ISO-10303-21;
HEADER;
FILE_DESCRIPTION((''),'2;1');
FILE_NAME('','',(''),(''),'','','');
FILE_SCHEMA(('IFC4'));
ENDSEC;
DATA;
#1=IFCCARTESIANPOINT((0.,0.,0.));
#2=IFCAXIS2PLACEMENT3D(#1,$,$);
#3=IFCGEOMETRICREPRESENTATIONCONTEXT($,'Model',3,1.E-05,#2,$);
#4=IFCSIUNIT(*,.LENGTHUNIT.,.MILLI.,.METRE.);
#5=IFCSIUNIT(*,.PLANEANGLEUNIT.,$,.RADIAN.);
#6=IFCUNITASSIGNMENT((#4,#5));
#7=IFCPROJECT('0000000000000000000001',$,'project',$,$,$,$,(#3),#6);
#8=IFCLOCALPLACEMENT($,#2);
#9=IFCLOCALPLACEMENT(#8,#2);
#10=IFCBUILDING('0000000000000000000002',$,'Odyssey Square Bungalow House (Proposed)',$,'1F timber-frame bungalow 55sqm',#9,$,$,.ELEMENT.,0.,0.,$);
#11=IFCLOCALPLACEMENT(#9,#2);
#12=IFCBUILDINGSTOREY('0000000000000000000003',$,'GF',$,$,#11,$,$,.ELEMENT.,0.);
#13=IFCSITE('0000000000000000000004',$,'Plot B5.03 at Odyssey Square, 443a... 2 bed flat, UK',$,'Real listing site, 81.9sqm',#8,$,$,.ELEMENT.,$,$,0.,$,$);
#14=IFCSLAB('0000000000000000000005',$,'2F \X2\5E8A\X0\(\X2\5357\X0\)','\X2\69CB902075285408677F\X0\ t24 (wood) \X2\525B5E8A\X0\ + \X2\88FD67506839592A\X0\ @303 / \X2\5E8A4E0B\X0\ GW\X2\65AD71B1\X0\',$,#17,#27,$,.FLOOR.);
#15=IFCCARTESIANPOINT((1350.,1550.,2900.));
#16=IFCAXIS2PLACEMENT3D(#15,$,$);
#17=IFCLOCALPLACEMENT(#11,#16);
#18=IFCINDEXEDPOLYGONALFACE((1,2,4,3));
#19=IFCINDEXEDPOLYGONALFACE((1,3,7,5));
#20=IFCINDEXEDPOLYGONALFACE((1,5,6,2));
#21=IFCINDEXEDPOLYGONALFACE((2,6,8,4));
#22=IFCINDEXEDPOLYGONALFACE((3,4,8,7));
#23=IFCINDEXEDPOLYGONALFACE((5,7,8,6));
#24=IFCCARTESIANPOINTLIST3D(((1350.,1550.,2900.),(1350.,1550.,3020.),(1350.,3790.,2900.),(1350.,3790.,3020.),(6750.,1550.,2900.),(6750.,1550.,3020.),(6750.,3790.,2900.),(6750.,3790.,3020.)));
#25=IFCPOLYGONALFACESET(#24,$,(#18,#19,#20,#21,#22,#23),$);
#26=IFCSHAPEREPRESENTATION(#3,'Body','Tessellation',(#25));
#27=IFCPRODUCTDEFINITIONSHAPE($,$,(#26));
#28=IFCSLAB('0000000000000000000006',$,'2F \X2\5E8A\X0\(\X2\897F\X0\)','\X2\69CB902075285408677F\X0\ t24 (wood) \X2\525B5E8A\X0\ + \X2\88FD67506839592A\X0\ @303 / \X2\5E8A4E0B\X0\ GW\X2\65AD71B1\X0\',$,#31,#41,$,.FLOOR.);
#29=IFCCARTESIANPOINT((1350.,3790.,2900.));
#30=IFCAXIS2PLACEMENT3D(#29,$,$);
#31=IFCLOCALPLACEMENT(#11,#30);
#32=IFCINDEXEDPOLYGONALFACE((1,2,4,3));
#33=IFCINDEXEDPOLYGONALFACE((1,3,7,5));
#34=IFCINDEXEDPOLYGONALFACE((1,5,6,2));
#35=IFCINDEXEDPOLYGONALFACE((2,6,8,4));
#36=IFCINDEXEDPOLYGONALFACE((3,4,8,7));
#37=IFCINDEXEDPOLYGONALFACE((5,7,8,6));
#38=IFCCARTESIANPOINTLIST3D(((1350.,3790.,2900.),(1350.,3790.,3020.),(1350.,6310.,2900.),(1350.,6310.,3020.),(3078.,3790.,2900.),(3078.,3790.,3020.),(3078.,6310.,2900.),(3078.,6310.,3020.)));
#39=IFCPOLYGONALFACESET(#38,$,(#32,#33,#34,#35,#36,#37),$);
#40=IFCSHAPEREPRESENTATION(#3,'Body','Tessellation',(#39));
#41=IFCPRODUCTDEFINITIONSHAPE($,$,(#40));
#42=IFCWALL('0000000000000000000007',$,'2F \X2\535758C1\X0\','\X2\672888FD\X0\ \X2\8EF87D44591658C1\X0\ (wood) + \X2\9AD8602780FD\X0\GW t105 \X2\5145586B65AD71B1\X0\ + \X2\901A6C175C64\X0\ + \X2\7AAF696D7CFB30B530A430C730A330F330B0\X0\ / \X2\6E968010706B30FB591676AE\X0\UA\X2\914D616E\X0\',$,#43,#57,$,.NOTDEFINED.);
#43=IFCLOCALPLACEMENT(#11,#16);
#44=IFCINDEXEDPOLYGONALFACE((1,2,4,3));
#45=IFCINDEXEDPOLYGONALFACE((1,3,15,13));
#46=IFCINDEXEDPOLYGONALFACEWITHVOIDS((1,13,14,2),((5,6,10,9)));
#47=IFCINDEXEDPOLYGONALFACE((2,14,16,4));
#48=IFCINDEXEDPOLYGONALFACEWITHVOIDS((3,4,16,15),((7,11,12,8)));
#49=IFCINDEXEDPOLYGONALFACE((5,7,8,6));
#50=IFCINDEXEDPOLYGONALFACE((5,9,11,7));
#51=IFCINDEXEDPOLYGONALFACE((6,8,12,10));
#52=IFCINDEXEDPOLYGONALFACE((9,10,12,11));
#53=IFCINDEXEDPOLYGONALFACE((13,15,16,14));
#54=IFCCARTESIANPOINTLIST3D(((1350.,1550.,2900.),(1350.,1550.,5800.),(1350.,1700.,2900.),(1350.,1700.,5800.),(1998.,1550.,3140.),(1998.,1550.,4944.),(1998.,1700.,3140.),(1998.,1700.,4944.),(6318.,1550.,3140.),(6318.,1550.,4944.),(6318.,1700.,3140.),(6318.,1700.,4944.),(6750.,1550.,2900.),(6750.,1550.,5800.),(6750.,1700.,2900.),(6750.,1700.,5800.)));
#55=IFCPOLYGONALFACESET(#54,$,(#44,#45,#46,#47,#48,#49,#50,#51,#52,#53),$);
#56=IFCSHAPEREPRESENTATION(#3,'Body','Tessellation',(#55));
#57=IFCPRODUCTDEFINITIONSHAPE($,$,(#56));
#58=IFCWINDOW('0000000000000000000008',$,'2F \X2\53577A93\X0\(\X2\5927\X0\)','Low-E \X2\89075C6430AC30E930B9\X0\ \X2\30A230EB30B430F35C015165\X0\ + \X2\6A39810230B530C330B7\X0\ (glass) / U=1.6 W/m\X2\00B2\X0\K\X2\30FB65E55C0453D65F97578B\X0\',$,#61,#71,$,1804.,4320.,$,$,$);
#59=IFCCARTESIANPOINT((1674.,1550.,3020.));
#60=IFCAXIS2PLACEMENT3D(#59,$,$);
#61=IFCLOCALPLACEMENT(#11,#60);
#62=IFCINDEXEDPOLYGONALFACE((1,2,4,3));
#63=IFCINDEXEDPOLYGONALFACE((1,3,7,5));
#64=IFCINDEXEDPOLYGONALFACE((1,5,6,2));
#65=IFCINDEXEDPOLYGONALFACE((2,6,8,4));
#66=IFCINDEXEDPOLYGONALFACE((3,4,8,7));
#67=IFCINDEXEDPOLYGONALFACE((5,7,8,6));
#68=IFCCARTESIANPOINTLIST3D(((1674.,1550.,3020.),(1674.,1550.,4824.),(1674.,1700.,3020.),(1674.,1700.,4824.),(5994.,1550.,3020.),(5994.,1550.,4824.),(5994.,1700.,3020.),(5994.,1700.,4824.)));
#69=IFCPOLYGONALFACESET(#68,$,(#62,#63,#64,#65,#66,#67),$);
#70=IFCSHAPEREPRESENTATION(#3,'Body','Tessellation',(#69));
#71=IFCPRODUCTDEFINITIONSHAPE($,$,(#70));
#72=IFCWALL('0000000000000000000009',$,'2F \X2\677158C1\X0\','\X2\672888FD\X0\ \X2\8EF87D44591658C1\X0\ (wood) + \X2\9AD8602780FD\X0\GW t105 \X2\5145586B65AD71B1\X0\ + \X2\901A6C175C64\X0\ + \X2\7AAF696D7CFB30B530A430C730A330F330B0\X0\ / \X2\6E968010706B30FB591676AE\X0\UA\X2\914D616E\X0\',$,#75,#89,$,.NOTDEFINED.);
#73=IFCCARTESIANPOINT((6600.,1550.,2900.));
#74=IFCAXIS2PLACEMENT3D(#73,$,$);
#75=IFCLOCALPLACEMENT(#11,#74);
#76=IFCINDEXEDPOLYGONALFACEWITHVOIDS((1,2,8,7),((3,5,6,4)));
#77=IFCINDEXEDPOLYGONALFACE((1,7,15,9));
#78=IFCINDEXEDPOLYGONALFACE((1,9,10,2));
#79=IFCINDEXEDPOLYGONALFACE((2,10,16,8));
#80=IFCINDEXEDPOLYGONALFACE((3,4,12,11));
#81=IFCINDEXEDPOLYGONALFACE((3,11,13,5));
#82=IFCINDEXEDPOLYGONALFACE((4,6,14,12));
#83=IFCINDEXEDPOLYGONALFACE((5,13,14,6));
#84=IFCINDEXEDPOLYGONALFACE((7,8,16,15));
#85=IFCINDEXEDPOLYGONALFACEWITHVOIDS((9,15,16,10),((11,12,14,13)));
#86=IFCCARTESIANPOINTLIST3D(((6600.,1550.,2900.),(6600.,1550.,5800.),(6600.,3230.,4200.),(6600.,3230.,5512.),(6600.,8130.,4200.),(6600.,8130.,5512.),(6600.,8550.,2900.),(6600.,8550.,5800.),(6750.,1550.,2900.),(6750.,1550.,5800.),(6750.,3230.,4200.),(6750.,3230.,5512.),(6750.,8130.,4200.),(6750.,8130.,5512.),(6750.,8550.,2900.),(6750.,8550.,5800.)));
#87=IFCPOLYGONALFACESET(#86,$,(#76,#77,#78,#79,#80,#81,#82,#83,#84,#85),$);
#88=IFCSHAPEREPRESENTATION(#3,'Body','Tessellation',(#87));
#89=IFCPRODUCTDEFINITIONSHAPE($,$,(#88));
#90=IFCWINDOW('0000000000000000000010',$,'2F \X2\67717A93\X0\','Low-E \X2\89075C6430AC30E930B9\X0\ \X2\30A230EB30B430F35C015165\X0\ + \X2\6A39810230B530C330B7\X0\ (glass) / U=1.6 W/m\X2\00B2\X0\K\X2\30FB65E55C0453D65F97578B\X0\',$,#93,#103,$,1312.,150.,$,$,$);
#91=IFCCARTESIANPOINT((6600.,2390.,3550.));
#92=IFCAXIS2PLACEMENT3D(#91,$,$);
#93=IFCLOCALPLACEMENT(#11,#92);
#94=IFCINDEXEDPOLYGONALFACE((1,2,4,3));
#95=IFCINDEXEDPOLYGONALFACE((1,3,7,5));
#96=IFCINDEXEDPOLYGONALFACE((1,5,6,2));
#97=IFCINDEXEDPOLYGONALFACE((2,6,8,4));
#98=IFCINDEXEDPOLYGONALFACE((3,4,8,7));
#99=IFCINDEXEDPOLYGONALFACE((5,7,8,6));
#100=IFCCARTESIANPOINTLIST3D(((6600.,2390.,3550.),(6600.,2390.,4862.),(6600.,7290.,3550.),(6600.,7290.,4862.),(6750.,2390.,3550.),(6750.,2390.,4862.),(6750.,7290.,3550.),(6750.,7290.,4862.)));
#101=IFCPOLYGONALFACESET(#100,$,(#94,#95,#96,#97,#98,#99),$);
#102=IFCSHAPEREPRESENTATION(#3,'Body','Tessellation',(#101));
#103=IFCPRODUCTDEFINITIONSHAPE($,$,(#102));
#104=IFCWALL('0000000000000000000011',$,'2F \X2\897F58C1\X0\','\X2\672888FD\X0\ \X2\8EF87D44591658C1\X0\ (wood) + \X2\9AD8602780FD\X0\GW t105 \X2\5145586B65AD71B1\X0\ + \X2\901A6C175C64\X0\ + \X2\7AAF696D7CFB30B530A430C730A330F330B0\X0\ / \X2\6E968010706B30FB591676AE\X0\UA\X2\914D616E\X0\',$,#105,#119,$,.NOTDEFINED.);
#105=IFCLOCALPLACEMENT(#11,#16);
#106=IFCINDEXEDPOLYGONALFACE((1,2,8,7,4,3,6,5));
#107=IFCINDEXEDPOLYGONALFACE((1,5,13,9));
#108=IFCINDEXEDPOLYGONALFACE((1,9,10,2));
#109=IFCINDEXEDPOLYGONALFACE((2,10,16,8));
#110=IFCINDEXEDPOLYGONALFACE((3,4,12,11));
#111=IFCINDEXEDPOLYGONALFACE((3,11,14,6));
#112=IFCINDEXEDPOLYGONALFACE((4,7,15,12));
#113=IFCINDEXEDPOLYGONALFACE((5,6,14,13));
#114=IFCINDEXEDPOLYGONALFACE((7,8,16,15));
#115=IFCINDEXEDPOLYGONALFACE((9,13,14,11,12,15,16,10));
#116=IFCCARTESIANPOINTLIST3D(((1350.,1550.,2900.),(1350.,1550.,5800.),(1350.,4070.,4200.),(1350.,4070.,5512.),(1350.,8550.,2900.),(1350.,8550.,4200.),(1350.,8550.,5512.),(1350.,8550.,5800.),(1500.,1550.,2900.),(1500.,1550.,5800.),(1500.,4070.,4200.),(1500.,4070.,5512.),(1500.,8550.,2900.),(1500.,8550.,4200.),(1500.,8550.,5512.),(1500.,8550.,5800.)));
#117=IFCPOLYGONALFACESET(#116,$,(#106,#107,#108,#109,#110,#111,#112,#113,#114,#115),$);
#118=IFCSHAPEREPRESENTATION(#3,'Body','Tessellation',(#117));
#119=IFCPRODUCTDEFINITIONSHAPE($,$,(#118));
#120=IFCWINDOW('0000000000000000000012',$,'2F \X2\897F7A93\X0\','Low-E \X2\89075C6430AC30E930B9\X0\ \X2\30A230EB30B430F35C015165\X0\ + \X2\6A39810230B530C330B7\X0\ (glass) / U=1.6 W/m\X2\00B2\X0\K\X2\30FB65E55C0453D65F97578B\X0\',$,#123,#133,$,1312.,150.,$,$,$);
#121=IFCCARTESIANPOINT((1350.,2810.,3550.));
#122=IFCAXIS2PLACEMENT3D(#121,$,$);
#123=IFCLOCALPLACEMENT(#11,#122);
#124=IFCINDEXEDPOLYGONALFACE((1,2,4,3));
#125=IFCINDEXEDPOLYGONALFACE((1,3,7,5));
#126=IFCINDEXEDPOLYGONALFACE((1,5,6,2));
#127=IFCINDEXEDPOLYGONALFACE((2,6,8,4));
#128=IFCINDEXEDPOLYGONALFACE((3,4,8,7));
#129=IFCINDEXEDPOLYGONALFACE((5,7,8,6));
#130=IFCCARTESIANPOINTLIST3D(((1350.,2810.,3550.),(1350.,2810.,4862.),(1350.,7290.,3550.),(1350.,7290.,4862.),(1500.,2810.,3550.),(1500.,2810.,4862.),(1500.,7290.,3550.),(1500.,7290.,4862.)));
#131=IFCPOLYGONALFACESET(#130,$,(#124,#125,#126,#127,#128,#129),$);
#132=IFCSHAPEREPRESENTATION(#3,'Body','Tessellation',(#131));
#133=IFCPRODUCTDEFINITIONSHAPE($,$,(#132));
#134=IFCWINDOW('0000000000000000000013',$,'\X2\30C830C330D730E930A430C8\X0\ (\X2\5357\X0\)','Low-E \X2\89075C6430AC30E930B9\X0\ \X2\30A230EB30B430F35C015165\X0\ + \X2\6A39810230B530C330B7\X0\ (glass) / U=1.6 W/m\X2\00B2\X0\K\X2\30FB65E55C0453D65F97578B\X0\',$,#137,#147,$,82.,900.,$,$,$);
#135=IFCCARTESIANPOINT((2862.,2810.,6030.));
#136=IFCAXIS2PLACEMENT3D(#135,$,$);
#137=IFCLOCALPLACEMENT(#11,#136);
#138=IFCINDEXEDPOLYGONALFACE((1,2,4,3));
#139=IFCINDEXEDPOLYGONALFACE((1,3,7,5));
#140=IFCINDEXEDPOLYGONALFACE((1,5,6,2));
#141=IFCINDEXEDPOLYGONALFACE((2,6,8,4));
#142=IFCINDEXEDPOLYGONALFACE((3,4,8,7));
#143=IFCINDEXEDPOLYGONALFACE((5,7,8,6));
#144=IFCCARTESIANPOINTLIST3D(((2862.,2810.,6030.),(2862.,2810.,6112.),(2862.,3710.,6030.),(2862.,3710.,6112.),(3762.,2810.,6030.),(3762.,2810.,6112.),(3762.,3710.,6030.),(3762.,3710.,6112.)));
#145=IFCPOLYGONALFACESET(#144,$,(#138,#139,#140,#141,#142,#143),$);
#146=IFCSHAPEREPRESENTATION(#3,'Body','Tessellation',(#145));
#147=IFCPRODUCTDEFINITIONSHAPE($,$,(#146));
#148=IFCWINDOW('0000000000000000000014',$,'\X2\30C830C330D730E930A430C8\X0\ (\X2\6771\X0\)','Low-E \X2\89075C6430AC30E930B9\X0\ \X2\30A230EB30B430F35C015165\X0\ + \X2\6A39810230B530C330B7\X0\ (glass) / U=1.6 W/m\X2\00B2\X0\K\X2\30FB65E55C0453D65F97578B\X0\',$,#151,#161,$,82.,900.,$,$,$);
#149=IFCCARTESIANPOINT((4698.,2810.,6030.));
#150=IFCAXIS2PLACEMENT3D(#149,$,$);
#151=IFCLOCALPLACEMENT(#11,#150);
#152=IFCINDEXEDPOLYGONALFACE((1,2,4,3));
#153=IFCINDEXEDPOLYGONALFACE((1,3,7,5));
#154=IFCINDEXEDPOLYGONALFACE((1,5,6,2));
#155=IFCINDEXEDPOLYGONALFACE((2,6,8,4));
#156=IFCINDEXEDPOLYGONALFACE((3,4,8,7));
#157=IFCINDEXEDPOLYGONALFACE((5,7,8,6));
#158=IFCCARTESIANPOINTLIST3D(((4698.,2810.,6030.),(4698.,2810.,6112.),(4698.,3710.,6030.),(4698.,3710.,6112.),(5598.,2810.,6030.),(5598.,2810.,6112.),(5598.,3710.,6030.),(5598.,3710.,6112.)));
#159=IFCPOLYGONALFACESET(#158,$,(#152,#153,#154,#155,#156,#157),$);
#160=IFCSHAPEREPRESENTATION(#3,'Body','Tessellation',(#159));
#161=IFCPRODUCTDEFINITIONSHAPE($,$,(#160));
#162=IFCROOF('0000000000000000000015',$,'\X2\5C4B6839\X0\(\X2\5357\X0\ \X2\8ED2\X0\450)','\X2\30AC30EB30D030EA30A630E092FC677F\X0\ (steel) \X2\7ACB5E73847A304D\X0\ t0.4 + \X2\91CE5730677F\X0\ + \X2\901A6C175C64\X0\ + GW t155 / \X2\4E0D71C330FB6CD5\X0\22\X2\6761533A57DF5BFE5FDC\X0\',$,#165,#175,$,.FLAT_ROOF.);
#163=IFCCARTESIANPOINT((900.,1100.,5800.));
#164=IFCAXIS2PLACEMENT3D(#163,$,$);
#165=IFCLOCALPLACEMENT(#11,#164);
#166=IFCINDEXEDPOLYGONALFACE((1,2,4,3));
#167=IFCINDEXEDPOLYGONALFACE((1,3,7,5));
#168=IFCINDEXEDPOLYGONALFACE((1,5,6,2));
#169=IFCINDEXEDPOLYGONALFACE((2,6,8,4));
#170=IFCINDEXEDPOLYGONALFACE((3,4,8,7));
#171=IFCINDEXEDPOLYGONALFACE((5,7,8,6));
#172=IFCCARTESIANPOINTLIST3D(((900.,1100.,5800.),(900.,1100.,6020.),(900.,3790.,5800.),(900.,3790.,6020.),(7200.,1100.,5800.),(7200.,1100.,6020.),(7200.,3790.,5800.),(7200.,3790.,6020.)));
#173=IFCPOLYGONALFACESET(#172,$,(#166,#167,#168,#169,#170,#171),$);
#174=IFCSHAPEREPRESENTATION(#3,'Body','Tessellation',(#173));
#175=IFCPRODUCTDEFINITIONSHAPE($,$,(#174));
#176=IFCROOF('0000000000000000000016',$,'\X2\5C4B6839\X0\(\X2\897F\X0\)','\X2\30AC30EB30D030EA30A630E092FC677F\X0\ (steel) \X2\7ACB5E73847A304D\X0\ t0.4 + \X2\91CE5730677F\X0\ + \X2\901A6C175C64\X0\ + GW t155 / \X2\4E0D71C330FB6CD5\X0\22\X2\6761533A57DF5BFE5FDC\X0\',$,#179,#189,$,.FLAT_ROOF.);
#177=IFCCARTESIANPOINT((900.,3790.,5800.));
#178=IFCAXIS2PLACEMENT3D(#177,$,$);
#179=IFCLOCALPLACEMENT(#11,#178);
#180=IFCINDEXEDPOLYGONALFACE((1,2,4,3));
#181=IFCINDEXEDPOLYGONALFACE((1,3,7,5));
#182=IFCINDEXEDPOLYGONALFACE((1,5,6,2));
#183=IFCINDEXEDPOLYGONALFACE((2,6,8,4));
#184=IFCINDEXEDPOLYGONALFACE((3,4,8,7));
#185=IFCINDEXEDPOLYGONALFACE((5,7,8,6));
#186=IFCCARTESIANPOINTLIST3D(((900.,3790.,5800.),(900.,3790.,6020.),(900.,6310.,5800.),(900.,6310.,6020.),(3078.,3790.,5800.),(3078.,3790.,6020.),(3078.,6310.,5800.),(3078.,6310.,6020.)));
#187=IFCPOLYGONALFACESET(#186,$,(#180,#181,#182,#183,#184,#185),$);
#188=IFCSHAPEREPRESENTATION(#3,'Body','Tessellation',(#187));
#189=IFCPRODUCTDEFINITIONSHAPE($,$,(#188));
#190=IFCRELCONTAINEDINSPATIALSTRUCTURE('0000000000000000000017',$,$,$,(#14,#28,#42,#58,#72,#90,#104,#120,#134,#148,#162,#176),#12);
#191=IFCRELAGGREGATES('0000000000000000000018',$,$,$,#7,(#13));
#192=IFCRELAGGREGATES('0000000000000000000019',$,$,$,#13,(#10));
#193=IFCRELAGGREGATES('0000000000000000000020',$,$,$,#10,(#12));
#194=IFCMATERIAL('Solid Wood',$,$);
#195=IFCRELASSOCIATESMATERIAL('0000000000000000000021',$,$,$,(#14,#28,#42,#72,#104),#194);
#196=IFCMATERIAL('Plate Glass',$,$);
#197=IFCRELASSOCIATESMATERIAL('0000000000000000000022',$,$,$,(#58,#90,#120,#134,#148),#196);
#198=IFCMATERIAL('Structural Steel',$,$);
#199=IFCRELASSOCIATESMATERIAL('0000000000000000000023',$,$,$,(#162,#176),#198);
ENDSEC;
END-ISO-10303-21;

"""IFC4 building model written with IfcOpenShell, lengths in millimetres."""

from ifc_helpers import new_model, si_unit, frame, frame_2d, origin, place, context, project, spatial, rectangle, extrude, material, element, fill, save


model = new_model("IFC4")

# Units and contexts
model_context = context("Model", 3, precision=1e-05, world=origin())
ifc_project = project(units=[si_unit("LENGTHUNIT", "METRE", prefix="MILLI"), si_unit("PLANEANGLEUNIT", "RADIAN")], contexts=[model_context])

# Site, building, storey
site_placement = place(None, origin())
site = spatial("IfcSite", under=ifc_project, at=site_placement, Name="Plot B5.03 at Odyssey Square, 443a... 2 bed flat, UK", ObjectType="Real listing site, 81.9sqm", CompositionType="ELEMENT", RefElevation=0.0)
building_placement = place(site_placement, origin())
building = spatial("IfcBuilding", under=site, at=building_placement, Name="Odyssey Square Bungalow House (Proposed)", ObjectType="1F timber-frame bungalow 55sqm", CompositionType="ELEMENT", ElevationOfRefHeight=0.0, ElevationOfTerrain=0.0)
storey_placement = place(building_placement, origin())
storey = spatial("IfcBuildingStorey", under=building, at=storey_placement, Name="GF", CompositionType="ELEMENT", Elevation=0.0)

# Slabs
ifc_material_1 = material(Name="Solid Wood")
slab_1_placement = place(storey_placement, frame((1350.0, 1550.0, 2900.0)))
element("IfcSlab", 1, at=slab_1_placement, inside=storey, material=ifc_material_1, Name="2F 床(南)", Description="構造用合板 t24 (wood) 剛床 + 製材根太 @303 / 床下 GW断熱", PredefinedType="FLOOR", context=model_context, shape_type="SweptSolid", body=[
    extrude(rectangle(XDim=5400.0, YDim=2240.0, at=frame_2d((2700.0, 1120.0))), frame((1350.0, 1550.0, 2900.0)), (0.0, 0.0, 1.0), 120.0),
])
slab_2_placement = place(storey_placement, frame((1350.0, 3790.0, 2900.0)))
element("IfcSlab", 2, at=slab_2_placement, inside=storey, material=ifc_material_1, Name="2F 床(西)", Description="構造用合板 t24 (wood) 剛床 + 製材根太 @303 / 床下 GW断熱", PredefinedType="FLOOR", context=model_context, shape_type="SweptSolid", body=[
    extrude(rectangle(XDim=1728.0, YDim=2520.0, at=frame_2d((864.0, 1260.0))), frame((1350.0, 3790.0, 2900.0)), (0.0, 0.0, 1.0), 120.0),
])

# Walls, openings, windows
wall_1_placement = place(storey_placement, frame((1350.0, 1550.0, 2900.0)))
wall_1 = element("IfcWall", 3, at=wall_1_placement, inside=storey, material=ifc_material_1, Name="2F 南壁", Description="木製 軸組外壁 (wood) + 高性能GW t105 充填断熱 + 通気層 + 窯業系サイディング / 準耐火・外皮UA配慮", PredefinedType="NOTDEFINED", context=model_context, shape_type="SweptSolid", body=[
    extrude(rectangle(XDim=5400.0, YDim=150.0, at=frame_2d((2700.0, 75.0))), frame((1350.0, 1550.0, 2900.0)), (0.0, 0.0, 1.0), 2900.0),
])
opening_1_placement = place(storey_placement, frame((1674.0, 1550.0, 3020.0)))
opening_1 = element("IfcOpeningElement", 4, at=opening_1_placement, cuts=wall_1, PredefinedType="NOTDEFINED", context=model_context, shape_type="SweptSolid", body=[
    extrude(rectangle(XDim=4320.0, YDim=150.0, at=frame_2d((2160.0, 75.0))), frame((1674.0, 1550.0, 3020.0)), (0.0, 0.0, 1.0), 1804.0),
])
ifc_material_2 = material(Name="Plate Glass")
window_1_placement = place(storey_placement, frame((1674.0, 1550.0, 3020.0)))
window_1 = element("IfcWindow", 5, at=window_1_placement, inside=storey, material=ifc_material_2, Name="2F 南窓(大)", Description="Low-E 複層ガラス アルゴン封入 + 樹脂サッシ (glass) / U=1.6 W/m²K・日射取得型", OverallHeight=1804.0, OverallWidth=4320.0, context=model_context, shape_type="SweptSolid", body=[
    extrude(rectangle(XDim=4320.0, YDim=150.0, at=frame_2d((2160.0, 75.0))), frame((1674.0, 1550.0, 3020.0)), (0.0, 0.0, 1.0), 1804.0),
])
fill(opening_1, window_1)
wall_2_placement = place(storey_placement, frame((6600.0, 1550.0, 2900.0)))
wall_2 = element("IfcWall", 6, at=wall_2_placement, inside=storey, material=ifc_material_1, Name="2F 東壁", Description="木製 軸組外壁 (wood) + 高性能GW t105 充填断熱 + 通気層 + 窯業系サイディング / 準耐火・外皮UA配慮", PredefinedType="NOTDEFINED", context=model_context, shape_type="SweptSolid", body=[
    extrude(rectangle(XDim=150.0, YDim=7000.0, at=frame_2d((75.0, 3500.0))), frame((6600.0, 1550.0, 2900.0)), (0.0, 0.0, 1.0), 2900.0),
])
opening_2_placement = place(storey_placement, frame((6600.0, 2390.0, 3550.0)))
opening_2 = element("IfcOpeningElement", 7, at=opening_2_placement, cuts=wall_2, PredefinedType="NOTDEFINED", context=model_context, shape_type="SweptSolid", body=[
    extrude(rectangle(XDim=150.0, YDim=4900.0, at=frame_2d((75.0, 2450.0))), frame((6600.0, 2390.0, 3550.0)), (0.0, 0.0, 1.0), 1312.0),
])
window_2_placement = place(storey_placement, frame((6600.0, 2390.0, 3550.0)))
window_2 = element("IfcWindow", 8, at=window_2_placement, inside=storey, material=ifc_material_2, Name="2F 東窓", Description="Low-E 複層ガラス アルゴン封入 + 樹脂サッシ (glass) / U=1.6 W/m²K・日射取得型", OverallHeight=1312.0, OverallWidth=150.0, context=model_context, shape_type="SweptSolid", body=[
    extrude(rectangle(XDim=150.0, YDim=4900.0, at=frame_2d((75.0, 2450.0))), frame((6600.0, 2390.0, 3550.0)), (0.0, 0.0, 1.0), 1312.0),
])
fill(opening_2, window_2)
wall_3_placement = place(storey_placement, frame((1350.0, 1550.0, 2900.0)))
wall_3 = element("IfcWall", 9, at=wall_3_placement, inside=storey, material=ifc_material_1, Name="2F 西壁", Description="木製 軸組外壁 (wood) + 高性能GW t105 充填断熱 + 通気層 + 窯業系サイディング / 準耐火・外皮UA配慮", PredefinedType="NOTDEFINED", context=model_context, shape_type="SweptSolid", body=[
    extrude(rectangle(XDim=150.0, YDim=7000.0, at=frame_2d((75.0, 3500.0))), frame((1350.0, 1550.0, 2900.0)), (0.0, 0.0, 1.0), 2900.0),
])
opening_3_placement = place(storey_placement, frame((1350.0, 2810.0, 3550.0)))
opening_3 = element("IfcOpeningElement", 10, at=opening_3_placement, cuts=wall_3, PredefinedType="NOTDEFINED", context=model_context, shape_type="SweptSolid", body=[
    extrude(rectangle(XDim=150.0, YDim=4480.0, at=frame_2d((75.0, 2240.0))), frame((1350.0, 2810.0, 3550.0)), (0.0, 0.0, 1.0), 1312.0),
])
window_3_placement = place(storey_placement, frame((1350.0, 2810.0, 3550.0)))
window_3 = element("IfcWindow", 11, at=window_3_placement, inside=storey, material=ifc_material_2, Name="2F 西窓", Description="Low-E 複層ガラス アルゴン封入 + 樹脂サッシ (glass) / U=1.6 W/m²K・日射取得型", OverallHeight=1312.0, OverallWidth=150.0, context=model_context, shape_type="SweptSolid", body=[
    extrude(rectangle(XDim=150.0, YDim=4480.0, at=frame_2d((75.0, 2240.0))), frame((1350.0, 2810.0, 3550.0)), (0.0, 0.0, 1.0), 1312.0),
])
fill(opening_3, window_3)

# Windows
window_4_placement = place(storey_placement, frame((2862.0, 2810.0, 6030.0)))
element("IfcWindow", 12, at=window_4_placement, inside=storey, material=ifc_material_2, Name="トップライト (南)", Description="Low-E 複層ガラス アルゴン封入 + 樹脂サッシ (glass) / U=1.6 W/m²K・日射取得型", OverallHeight=82.0, OverallWidth=900.0, context=model_context, shape_type="SweptSolid", body=[
    extrude(rectangle(XDim=900.0, YDim=900.0, at=frame_2d((450.0, 450.0))), frame((2862.0, 2810.0, 6030.0)), (0.0, 0.0, 1.0), 82.0),
])
window_5_placement = place(storey_placement, frame((4698.0, 2810.0, 6030.0)))
element("IfcWindow", 13, at=window_5_placement, inside=storey, material=ifc_material_2, Name="トップライト (東)", Description="Low-E 複層ガラス アルゴン封入 + 樹脂サッシ (glass) / U=1.6 W/m²K・日射取得型", OverallHeight=82.0, OverallWidth=900.0, context=model_context, shape_type="SweptSolid", body=[
    extrude(rectangle(XDim=900.0, YDim=900.0, at=frame_2d((450.0, 450.0))), frame((4698.0, 2810.0, 6030.0)), (0.0, 0.0, 1.0), 82.0),
])

# Roofs
ifc_material_3 = material(Name="Structural Steel")
roof_1_placement = place(storey_placement, frame((900.0, 1100.0, 5800.0)))
element("IfcRoof", 14, at=roof_1_placement, inside=storey, material=ifc_material_3, Name="屋根(南 軒450)", Description="ガルバリウム鋼板 (steel) 立平葺き t0.4 + 野地板 + 通気層 + GW t155 / 不燃・法22条区域対応", PredefinedType="FLAT_ROOF", context=model_context, shape_type="SweptSolid", body=[
    extrude(rectangle(XDim=6300.0, YDim=2690.0, at=frame_2d((3150.0, 1345.0))), frame((900.0, 1100.0, 5800.0)), (0.0, 0.0, 1.0), 220.0),
])
roof_2_placement = place(storey_placement, frame((900.0, 3790.0, 5800.0)))
element("IfcRoof", 15, at=roof_2_placement, inside=storey, material=ifc_material_3, Name="屋根(西)", Description="ガルバリウム鋼板 (steel) 立平葺き t0.4 + 野地板 + 通気層 + GW t155 / 不燃・法22条区域対応", PredefinedType="FLAT_ROOF", context=model_context, shape_type="SweptSolid", body=[
    extrude(rectangle(XDim=2178.0, YDim=2520.0, at=frame_2d((1089.0, 1260.0))), frame((900.0, 3790.0, 5800.0)), (0.0, 0.0, 1.0), 220.0),
])

save(model, "model.ifc")
